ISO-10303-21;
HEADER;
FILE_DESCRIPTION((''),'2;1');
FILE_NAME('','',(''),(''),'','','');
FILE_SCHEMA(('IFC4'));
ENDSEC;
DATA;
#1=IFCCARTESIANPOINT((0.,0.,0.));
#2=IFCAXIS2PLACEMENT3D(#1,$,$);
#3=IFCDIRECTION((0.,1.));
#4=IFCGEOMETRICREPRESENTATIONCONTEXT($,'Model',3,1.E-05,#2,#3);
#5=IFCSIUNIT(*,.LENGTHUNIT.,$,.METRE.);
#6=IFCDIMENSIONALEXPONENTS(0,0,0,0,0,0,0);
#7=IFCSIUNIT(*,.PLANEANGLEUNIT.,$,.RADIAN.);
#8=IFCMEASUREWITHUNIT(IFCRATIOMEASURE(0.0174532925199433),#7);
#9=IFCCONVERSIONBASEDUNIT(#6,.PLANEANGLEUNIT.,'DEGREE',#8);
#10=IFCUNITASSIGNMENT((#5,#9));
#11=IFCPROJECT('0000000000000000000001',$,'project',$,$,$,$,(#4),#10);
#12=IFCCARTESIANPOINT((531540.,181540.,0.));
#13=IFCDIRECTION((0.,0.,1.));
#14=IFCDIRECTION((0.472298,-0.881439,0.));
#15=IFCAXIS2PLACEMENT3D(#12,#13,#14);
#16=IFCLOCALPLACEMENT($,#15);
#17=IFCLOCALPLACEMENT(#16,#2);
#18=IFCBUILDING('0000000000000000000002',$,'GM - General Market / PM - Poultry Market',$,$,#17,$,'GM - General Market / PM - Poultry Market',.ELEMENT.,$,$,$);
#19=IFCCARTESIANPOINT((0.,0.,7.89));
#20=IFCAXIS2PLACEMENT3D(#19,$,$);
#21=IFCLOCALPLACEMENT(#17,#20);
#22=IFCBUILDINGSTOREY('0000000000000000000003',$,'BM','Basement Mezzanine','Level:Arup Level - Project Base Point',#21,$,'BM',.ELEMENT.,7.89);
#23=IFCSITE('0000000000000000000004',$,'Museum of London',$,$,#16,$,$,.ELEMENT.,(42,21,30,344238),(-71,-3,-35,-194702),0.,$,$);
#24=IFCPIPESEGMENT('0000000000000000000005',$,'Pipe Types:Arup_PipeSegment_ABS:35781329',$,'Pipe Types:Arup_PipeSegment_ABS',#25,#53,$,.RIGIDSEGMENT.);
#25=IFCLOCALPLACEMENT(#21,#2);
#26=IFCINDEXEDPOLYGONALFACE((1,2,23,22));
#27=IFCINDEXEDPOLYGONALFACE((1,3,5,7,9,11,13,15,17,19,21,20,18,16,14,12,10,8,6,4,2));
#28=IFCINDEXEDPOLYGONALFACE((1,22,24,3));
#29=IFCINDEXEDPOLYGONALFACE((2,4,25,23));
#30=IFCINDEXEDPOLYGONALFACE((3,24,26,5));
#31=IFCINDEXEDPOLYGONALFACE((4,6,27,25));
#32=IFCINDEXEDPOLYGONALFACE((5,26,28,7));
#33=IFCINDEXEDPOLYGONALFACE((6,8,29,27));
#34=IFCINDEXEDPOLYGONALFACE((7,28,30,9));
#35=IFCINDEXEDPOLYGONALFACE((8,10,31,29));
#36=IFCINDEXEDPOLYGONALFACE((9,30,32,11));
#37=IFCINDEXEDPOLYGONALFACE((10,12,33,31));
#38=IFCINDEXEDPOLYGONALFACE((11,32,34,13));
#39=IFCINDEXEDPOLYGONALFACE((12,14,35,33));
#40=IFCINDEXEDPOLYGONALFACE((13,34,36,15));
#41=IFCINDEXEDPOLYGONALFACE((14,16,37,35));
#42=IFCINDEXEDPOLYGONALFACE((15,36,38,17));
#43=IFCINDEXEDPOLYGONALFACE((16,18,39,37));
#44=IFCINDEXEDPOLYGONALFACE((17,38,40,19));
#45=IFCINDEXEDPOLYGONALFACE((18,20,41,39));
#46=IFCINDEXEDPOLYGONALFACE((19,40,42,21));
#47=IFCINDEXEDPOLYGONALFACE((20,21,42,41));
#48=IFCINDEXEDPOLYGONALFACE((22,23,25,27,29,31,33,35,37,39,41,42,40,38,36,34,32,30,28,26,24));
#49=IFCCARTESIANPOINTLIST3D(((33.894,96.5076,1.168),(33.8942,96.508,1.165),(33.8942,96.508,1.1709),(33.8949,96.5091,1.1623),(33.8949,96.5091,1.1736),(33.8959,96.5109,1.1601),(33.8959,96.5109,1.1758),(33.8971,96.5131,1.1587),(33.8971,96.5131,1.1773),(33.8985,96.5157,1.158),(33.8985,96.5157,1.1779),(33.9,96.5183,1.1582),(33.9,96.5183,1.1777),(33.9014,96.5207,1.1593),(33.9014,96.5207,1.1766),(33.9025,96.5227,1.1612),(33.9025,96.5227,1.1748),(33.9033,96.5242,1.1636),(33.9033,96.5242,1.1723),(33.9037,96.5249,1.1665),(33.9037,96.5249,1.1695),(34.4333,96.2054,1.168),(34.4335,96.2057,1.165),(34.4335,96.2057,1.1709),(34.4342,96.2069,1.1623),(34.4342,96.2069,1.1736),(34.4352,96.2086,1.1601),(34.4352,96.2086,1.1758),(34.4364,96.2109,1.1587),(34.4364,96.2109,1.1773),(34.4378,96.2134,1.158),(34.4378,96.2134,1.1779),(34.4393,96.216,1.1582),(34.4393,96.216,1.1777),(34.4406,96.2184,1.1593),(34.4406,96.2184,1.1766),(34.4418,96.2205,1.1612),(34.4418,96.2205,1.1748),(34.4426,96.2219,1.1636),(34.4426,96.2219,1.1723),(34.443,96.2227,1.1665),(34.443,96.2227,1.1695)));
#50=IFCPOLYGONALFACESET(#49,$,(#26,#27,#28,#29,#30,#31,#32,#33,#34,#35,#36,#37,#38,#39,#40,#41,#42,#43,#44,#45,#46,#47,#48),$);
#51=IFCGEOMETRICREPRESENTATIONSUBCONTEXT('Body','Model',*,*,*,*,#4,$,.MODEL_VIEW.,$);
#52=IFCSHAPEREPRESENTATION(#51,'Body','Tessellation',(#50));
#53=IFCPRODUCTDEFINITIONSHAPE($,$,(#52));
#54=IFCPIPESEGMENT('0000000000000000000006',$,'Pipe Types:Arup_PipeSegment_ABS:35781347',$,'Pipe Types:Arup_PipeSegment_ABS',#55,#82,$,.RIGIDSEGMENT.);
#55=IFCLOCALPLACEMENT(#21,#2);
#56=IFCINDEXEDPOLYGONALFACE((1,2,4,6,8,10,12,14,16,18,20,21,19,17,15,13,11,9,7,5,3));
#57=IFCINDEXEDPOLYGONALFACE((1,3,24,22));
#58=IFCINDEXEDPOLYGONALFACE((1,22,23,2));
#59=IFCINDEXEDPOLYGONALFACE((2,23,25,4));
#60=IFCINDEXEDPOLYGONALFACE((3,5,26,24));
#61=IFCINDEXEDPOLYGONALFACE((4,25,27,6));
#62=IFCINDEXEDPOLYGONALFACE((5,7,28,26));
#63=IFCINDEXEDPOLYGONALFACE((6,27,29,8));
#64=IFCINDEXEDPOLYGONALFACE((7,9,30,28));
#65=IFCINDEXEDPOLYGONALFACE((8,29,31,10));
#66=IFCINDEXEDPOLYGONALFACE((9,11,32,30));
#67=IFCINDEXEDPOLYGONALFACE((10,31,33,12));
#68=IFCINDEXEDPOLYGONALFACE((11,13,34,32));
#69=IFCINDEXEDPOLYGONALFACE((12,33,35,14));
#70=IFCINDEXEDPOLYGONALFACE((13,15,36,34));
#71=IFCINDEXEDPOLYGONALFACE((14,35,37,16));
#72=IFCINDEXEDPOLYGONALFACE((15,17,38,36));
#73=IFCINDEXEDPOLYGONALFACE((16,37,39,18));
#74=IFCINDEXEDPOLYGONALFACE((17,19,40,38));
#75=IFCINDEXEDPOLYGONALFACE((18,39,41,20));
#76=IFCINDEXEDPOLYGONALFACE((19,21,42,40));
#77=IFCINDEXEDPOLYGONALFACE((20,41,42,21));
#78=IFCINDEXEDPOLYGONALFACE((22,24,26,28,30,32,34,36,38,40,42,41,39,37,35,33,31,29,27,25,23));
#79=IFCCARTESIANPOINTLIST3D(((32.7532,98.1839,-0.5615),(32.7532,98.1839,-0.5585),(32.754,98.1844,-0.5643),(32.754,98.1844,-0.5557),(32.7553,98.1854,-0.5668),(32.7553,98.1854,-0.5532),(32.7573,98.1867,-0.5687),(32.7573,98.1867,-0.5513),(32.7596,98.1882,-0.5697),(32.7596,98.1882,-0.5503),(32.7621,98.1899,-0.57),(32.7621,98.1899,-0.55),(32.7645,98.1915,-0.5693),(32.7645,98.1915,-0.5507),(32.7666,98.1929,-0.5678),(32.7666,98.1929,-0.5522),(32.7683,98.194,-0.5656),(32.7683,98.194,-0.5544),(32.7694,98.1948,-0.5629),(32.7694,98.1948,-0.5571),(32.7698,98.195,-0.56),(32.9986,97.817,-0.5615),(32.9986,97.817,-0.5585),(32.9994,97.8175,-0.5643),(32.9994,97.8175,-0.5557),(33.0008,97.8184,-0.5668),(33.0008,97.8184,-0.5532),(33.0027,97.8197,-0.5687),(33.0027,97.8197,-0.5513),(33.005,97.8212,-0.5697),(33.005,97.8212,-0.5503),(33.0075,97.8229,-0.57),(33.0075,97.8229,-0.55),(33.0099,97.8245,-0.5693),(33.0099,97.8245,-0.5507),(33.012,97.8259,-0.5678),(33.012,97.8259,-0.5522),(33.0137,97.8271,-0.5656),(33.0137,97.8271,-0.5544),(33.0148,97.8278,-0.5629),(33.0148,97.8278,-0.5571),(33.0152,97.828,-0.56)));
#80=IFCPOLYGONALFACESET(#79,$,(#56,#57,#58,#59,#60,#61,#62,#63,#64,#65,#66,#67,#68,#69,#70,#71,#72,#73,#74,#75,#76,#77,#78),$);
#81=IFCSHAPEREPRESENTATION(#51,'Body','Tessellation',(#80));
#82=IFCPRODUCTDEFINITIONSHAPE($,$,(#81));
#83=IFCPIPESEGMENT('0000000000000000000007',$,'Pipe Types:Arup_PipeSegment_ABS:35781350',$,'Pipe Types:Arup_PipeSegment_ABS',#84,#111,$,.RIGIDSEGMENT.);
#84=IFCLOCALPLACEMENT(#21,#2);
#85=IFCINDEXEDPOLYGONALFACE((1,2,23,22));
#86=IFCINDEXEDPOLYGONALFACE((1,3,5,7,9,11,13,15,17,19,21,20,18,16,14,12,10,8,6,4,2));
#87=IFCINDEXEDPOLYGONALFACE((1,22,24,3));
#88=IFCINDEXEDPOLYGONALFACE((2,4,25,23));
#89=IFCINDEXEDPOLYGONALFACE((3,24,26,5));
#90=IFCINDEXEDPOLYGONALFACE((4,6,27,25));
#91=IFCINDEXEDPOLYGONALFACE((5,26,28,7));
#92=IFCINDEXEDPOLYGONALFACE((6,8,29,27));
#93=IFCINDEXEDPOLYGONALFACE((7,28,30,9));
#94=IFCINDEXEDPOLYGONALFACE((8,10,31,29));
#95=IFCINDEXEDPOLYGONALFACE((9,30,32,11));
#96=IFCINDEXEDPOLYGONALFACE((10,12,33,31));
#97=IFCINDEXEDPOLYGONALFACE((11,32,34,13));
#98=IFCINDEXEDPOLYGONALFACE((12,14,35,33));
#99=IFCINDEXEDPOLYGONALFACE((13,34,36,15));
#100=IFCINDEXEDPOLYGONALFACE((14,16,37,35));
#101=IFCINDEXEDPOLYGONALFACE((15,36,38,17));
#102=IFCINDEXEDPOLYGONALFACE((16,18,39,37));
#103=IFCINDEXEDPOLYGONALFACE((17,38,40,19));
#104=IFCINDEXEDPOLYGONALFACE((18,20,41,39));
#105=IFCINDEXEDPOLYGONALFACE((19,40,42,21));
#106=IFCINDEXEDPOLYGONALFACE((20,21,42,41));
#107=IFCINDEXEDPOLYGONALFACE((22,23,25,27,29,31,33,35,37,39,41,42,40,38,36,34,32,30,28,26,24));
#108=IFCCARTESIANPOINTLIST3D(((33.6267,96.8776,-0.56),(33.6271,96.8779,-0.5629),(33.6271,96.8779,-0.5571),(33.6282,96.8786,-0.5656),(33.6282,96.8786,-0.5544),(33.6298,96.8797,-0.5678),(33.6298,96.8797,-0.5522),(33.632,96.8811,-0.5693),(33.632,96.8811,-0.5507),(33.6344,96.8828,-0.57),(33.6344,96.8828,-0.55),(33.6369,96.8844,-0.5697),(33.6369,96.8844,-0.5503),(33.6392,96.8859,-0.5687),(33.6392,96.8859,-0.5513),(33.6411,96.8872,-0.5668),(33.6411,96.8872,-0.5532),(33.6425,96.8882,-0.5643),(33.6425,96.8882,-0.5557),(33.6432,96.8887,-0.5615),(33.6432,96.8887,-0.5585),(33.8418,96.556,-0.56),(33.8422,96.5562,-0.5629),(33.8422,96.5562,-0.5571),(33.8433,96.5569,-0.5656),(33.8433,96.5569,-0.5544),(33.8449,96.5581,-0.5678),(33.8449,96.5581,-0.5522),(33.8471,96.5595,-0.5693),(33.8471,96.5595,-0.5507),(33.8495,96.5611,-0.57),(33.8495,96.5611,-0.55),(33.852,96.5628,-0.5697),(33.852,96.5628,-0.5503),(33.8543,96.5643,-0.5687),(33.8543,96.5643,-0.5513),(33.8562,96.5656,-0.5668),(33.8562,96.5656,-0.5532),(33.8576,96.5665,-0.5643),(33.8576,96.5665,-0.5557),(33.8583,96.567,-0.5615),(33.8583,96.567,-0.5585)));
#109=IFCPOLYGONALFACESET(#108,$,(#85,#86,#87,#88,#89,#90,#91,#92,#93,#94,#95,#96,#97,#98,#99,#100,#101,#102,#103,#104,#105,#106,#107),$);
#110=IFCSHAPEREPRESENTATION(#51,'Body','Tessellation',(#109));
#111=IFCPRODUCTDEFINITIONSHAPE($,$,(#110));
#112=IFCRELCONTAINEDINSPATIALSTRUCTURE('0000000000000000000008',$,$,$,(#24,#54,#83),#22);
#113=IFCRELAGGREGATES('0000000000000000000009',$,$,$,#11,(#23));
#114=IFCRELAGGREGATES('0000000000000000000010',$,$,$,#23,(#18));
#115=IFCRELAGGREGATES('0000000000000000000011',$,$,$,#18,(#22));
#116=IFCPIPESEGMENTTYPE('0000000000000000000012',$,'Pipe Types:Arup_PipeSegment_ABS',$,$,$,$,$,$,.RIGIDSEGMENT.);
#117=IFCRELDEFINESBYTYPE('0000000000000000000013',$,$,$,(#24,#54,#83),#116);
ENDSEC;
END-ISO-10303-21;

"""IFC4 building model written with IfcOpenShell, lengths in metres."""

from ifc_helpers import new_model, entity, si_unit, converted_unit, direction, frame, frame_2d, origin, origin_2d_with_axis, place, context, subcontext, project, spatial, circle, extrude, type_object, element, save


model = new_model("IFC4")

# Units and contexts
model_context = context("Model", 3, precision=1e-05, world=origin(), true_north=direction((0.0, 1.0)))
body_context = subcontext(model_context, "Body", "Model", "MODEL_VIEW")
ifc_project = project(units=[si_unit("LENGTHUNIT", "METRE"), converted_unit("PLANEANGLEUNIT", "DEGREE", entity("IfcRatioMeasure", 0.0174532925199433), si_unit("PLANEANGLEUNIT", "RADIAN"), dimensions=[0, 0, 0, 0, 0, 0, 0])], contexts=[model_context])

# Site, building, storey
site_placement = place(None, frame((531540.0, 181540.0, 0.0), z_axis=(0.0, 0.0, 1.0), x_axis=(0.472298, -0.881439, 0.0)))
site = spatial("IfcSite", under=ifc_project, at=site_placement, Name="Museum of London", CompositionType="ELEMENT", RefLatitude=(42, 21, 30, 344238), RefLongitude=(-71, -3, -35, -194702), RefElevation=0.0)
building_placement = place(site_placement, origin())
building = spatial("IfcBuilding", under=site, at=building_placement, Name="GM - General Market / PM - Poultry Market", LongName="GM - General Market / PM - Poultry Market", CompositionType="ELEMENT")
storey_placement = place(building_placement, frame((0.0, 0.0, 7.89)))
storey = spatial("IfcBuildingStorey", under=building, at=storey_placement, Name="BM", Description="Basement Mezzanine", ObjectType="Level:Arup Level - Project Base Point", LongName="BM", CompositionType="ELEMENT", Elevation=7.89)

# Pipe segments
pipe_segment_type_1 = type_object("IfcPipeSegmentType", Name="Pipe Types:Arup_PipeSegment_ABS", PredefinedType="RIGIDSEGMENT")
pipe_segment_1_placement = place(storey_placement, frame((33.8924, 96.2038, 1.1564)))
element("IfcPipeSegment", 1, at=pipe_segment_1_placement, inside=storey, type_object=pipe_segment_type_1, Name="Pipe Types:Arup_PipeSegment_ABS:35781329", ObjectType="Pipe Types:Arup_PipeSegment_ABS", PredefinedType="RIGIDSEGMENT", context=body_context, shape_type="SweptSolid", body=[
    extrude(circle(Radius=0.01, at=frame_2d((0.0, 0.0), x_axis=(1.0, 0.0))), frame((0.5458, 0.0103, 0.0116), z_axis=(-0.872349, 0.488884, 0.0), x_axis=(-0.488884, -0.872349, 0.0)), (0.0, 0.0, 1.0), 0.6182),
])
pipe_segment_2_placement = place(storey_placement, frame((32.7515, 97.8153, -0.5716)))
element("IfcPipeSegment", 2, at=pipe_segment_2_placement, inside=storey, type_object=pipe_segment_type_1, Name="Pipe Types:Arup_PipeSegment_ABS:35781347", ObjectType="Pipe Types:Arup_PipeSegment_ABS", PredefinedType="RIGIDSEGMENT", context=body_context, shape_type="SweptSolid", body=[
    extrude(circle(Radius=0.01, at=origin_2d_with_axis()), frame((0.2553, 0.0072, 0.0116), z_axis=(-0.555905, 0.831246, 0.0), x_axis=(0.831246, 0.555905, 0.0)), (0.0, 0.0, 1.0), 0.4415),
])
pipe_segment_3_placement = place(storey_placement, frame((33.6251, 96.5544, -0.5716)))
element("IfcPipeSegment", 3, at=pipe_segment_3_placement, inside=storey, type_object=pipe_segment_type_1, Name="Pipe Types:Arup_PipeSegment_ABS:35781350", ObjectType="Pipe Types:Arup_PipeSegment_ABS", PredefinedType="RIGIDSEGMENT", context=body_context, shape_type="SweptSolid", body=[
    extrude(circle(Radius=0.01, at=origin_2d_with_axis()), frame((0.225, 0.0072, 0.0116), z_axis=(-0.555905, 0.831246, 0.0), x_axis=(-0.831246, -0.555905, 0.0)), (0.0, 0.0, 1.0), 0.3869),
])

save(model, "model.ifc")
